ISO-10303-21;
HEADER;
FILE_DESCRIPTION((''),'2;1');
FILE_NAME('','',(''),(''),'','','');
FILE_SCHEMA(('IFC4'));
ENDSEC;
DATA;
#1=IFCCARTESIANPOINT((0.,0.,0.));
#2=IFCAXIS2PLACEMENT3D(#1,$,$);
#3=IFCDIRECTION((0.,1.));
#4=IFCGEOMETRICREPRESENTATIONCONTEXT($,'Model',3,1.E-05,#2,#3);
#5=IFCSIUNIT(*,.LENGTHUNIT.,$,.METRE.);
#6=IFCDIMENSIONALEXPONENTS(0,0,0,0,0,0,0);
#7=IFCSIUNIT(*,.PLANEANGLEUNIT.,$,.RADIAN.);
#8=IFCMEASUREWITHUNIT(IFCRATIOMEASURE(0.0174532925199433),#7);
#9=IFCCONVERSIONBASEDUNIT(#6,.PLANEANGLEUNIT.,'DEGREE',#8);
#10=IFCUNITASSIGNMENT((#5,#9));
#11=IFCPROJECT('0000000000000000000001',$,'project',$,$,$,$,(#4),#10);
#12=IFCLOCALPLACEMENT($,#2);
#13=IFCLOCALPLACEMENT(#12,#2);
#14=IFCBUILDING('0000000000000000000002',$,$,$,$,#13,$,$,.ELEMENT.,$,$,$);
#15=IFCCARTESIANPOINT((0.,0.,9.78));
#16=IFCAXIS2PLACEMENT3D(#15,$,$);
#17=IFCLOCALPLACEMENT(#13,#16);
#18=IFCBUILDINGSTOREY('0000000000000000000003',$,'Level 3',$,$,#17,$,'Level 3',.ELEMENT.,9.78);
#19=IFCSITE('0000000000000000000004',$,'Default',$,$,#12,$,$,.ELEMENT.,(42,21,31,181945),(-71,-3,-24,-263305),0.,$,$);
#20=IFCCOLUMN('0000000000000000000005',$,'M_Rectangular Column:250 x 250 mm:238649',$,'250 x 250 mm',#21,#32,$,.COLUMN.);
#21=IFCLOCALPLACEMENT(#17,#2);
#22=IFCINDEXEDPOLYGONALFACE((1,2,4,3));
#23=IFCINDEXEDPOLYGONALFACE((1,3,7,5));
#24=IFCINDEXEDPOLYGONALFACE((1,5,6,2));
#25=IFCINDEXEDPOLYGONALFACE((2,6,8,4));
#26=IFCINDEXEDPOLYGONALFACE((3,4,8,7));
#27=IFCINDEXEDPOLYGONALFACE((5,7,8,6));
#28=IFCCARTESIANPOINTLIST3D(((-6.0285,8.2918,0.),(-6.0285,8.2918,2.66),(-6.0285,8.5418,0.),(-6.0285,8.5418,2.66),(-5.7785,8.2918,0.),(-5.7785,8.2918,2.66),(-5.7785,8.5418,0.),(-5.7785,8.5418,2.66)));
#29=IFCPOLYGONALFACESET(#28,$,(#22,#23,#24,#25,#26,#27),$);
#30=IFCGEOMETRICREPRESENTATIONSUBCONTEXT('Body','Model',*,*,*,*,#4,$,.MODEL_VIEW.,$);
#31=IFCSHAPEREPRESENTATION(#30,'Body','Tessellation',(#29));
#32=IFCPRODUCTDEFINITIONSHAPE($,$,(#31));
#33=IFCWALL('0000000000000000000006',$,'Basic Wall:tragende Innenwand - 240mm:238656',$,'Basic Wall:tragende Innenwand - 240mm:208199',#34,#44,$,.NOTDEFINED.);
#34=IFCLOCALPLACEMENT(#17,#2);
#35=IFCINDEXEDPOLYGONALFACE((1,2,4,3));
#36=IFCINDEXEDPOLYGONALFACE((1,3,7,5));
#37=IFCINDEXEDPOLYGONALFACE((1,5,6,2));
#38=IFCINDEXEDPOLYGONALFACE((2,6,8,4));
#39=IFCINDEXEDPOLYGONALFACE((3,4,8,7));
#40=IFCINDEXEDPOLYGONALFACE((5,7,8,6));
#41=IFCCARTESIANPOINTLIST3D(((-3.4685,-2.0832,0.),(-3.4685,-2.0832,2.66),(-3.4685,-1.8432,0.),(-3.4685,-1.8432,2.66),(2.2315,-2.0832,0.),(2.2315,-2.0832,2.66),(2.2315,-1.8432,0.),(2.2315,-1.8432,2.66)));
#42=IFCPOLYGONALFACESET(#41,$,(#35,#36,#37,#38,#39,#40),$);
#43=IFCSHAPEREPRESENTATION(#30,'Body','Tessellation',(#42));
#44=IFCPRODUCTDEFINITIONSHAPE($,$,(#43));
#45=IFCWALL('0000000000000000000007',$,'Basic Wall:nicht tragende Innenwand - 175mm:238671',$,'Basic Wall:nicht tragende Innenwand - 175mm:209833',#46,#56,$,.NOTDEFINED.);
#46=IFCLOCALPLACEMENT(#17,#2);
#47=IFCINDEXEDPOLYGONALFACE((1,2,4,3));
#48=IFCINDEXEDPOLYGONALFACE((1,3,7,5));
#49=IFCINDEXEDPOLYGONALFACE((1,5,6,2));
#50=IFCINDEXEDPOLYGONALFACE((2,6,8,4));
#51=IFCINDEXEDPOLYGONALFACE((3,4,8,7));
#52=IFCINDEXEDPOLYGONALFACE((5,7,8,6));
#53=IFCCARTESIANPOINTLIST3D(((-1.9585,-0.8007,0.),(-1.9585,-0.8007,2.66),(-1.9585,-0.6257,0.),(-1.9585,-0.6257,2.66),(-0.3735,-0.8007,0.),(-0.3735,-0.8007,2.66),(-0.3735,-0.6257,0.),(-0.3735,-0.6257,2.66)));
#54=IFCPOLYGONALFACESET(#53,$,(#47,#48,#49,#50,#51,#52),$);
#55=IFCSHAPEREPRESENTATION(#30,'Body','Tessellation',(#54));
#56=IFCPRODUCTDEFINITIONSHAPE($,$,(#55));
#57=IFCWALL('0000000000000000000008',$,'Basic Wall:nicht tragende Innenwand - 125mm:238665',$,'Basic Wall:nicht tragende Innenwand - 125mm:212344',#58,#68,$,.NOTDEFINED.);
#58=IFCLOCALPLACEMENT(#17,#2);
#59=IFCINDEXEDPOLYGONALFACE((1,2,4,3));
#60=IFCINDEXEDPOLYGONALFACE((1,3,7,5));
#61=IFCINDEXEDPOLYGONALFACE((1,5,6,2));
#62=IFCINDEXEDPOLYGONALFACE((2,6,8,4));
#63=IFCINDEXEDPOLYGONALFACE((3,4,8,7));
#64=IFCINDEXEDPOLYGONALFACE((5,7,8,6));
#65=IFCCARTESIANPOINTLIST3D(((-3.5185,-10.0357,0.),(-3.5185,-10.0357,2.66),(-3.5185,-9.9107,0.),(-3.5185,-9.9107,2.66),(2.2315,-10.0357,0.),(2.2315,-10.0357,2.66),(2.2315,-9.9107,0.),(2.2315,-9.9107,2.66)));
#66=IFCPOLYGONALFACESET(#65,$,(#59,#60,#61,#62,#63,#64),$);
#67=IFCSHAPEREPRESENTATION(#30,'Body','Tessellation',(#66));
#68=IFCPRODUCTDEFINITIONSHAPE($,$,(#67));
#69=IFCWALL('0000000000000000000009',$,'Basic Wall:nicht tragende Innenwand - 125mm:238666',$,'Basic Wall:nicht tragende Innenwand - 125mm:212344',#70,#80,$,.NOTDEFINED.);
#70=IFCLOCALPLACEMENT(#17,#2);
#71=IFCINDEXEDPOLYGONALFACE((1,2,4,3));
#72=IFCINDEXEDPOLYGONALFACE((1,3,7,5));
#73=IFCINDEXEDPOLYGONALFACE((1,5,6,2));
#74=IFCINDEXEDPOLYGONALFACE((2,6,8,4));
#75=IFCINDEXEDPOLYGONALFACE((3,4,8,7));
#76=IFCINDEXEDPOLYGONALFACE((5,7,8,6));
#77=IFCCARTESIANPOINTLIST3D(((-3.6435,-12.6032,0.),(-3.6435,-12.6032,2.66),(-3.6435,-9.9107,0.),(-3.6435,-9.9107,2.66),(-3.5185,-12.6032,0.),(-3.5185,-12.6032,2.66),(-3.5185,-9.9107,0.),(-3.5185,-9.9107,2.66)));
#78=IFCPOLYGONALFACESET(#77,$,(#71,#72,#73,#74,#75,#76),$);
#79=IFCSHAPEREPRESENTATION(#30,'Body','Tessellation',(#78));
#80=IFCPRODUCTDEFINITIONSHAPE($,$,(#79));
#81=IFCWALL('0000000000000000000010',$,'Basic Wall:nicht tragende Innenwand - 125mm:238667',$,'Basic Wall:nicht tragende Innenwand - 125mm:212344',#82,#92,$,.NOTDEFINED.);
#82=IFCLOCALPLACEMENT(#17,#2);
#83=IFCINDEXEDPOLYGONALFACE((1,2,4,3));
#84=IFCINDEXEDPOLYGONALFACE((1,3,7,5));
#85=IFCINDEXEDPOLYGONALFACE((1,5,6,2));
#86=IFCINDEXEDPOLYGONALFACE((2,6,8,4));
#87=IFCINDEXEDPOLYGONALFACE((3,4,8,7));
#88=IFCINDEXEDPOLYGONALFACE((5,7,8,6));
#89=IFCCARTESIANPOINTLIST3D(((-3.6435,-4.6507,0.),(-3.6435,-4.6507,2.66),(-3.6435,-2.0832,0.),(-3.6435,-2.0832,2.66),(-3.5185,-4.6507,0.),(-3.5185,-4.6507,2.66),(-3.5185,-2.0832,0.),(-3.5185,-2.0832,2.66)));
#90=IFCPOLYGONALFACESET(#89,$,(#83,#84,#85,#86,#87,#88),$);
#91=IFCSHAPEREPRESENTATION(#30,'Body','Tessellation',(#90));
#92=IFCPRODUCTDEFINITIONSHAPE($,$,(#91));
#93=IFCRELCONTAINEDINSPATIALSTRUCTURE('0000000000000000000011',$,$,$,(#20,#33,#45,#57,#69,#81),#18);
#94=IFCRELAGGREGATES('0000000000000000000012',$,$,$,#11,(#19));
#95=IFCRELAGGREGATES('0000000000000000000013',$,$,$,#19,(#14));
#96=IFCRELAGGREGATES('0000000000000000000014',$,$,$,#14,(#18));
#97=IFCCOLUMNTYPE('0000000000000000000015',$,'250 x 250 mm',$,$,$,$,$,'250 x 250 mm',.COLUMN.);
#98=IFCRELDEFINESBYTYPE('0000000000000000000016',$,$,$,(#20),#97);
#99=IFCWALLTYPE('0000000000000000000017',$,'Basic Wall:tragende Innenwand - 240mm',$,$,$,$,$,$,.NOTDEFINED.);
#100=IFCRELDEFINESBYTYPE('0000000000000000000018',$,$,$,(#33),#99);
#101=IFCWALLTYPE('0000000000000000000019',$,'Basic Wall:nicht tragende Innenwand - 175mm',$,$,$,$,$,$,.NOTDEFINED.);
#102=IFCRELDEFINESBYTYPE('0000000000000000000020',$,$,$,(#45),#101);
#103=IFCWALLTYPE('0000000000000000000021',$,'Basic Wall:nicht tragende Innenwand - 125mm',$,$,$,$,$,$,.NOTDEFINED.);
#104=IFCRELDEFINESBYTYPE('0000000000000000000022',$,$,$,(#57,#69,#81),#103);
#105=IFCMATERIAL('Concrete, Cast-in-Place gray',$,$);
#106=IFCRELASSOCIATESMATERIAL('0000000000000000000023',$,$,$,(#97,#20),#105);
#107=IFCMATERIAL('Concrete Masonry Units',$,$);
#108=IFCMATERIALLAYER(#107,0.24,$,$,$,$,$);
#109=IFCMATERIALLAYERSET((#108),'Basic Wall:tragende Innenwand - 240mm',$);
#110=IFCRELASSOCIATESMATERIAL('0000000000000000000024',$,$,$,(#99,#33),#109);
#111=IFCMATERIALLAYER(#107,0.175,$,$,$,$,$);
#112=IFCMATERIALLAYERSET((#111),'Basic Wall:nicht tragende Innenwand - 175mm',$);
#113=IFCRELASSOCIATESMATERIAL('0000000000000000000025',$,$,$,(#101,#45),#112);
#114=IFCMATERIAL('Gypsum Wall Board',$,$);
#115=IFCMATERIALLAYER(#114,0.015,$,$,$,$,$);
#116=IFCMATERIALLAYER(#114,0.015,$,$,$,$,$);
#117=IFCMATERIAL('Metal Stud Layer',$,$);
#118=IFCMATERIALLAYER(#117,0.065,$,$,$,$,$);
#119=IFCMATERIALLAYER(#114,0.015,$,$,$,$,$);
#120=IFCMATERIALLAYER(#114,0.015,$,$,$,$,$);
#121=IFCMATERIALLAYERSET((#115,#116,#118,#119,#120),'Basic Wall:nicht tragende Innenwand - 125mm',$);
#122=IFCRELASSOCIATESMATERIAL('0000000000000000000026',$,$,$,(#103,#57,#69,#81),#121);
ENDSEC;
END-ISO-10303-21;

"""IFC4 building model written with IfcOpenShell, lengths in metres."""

from ifc_helpers import new_model, entity, si_unit, converted_unit, direction, frame, frame_2d, origin, place, context, subcontext, project, spatial, rectangle, extrude, source, transform, mapped, material, layer, layer_set, layer_usage, material_profile, profile_set, profile_usage, type_object, type_shapes, element, save


model = new_model("IFC4")

# Units and contexts
model_context = context("Model", 3, precision=1e-05, world=origin(), true_north=direction((0.0, 1.0)))
body_context = subcontext(model_context, "Body", "Model", "MODEL_VIEW")
ifc_project = project(units=[si_unit("LENGTHUNIT", "METRE"), converted_unit("PLANEANGLEUNIT", "DEGREE", entity("IfcRatioMeasure", 0.0174532925199433), si_unit("PLANEANGLEUNIT", "RADIAN"), dimensions=[0, 0, 0, 0, 0, 0, 0])], contexts=[model_context])

# Site, building, storey
site_placement = place(None, origin())
site = spatial("IfcSite", under=ifc_project, at=site_placement, Name="Default", CompositionType="ELEMENT", RefLatitude=(42, 21, 31, 181945), RefLongitude=(-71, -3, -24, -263305), RefElevation=0.0)
building_placement = place(site_placement, origin())
building = spatial("IfcBuilding", under=site, at=building_placement, CompositionType="ELEMENT")
storey_placement = place(building_placement, frame((0.0, 0.0, 9.78)))
storey = spatial("IfcBuildingStorey", under=building, at=storey_placement, Name="Level 3", LongName="Level 3", CompositionType="ELEMENT", Elevation=9.78)

# Column
ifc_material_1 = material(Name="Concrete, Cast-in-Place gray")
ifc_material_profile = material_profile(ifc_material_1, rectangle(XDim=0.25, YDim=0.25, at=frame_2d((0.0, 0.0), x_axis=(1.0, 0.0))))
ifc_profile_set = profile_set([ifc_material_profile], Name="250 x 250 mm")
ifc_profile_usage = profile_usage(ifc_profile_set)
column_type = type_object("IfcColumnType", Name="250 x 250 mm", ElementType="250 x 250 mm", PredefinedType="COLUMN", material=ifc_profile_set)
shared_shape_1 = source(origin(), body_context, "Body", "SweptSolid", [
    extrude(rectangle(XDim=0.25, YDim=0.25, at=frame_2d((0.0, 0.0), x_axis=(1.0, 0.0))), frame((-5.9035, 8.4168, 9.78), z_axis=(0.0, 0.0, 1.0), x_axis=(0.0, -1.0, 0.0)), (0.0, 0.0, 1.0), 2.66),
])
type_shapes(column_type, [shared_shape_1])
column_placement = place(storey_placement, frame((0.0, 0.0, -9.78)))
element("IfcColumn", 1, at=column_placement, inside=storey, type_object=column_type, material=ifc_profile_usage, Name="M_Rectangular Column:250 x 250 mm:238649", ObjectType="250 x 250 mm", PredefinedType="COLUMN", context=body_context, shape_type="MappedRepresentation", body=[
    mapped(shared_shape_1, transform((0.0, 0.0, 0.0), scale=1.0)),
])

# Walls
ifc_material_2 = material(Name="Concrete Masonry Units")
ifc_layer_1 = layer(ifc_material_2, 0.24)
ifc_layer_set_1 = layer_set([ifc_layer_1], Name="Basic Wall:tragende Innenwand - 240mm")
ifc_layer_usage_1 = layer_usage(ifc_layer_set_1, "AXIS2", "NEGATIVE", 0.12)
wall_type_1 = type_object("IfcWallType", Name="Basic Wall:tragende Innenwand - 240mm", PredefinedType="NOTDEFINED", material=ifc_layer_set_1)
wall_1_placement = place(storey_placement, frame((-3.4685, -1.9632, 0.0)))
element("IfcWall", 2, at=wall_1_placement, inside=storey, type_object=wall_type_1, material=ifc_layer_usage_1, Name="Basic Wall:tragende Innenwand - 240mm:238656", ObjectType="Basic Wall:tragende Innenwand - 240mm:208199", PredefinedType="NOTDEFINED", context=body_context, shape_type="SweptSolid", body=[
    extrude(rectangle(XDim=5.7, YDim=0.24, at=frame_2d((2.85, 0.0), x_axis=(-1.0, 0.0))), origin(), (0.0, 0.0, 1.0), 2.66),
])
ifc_layer_2 = layer(ifc_material_2, 0.175)
ifc_layer_set_2 = layer_set([ifc_layer_2], Name="Basic Wall:nicht tragende Innenwand - 175mm")
ifc_layer_usage_2 = layer_usage(ifc_layer_set_2, "AXIS2", "NEGATIVE", 0.0875)
wall_type_2 = type_object("IfcWallType", Name="Basic Wall:nicht tragende Innenwand - 175mm", PredefinedType="NOTDEFINED", material=ifc_layer_set_2)
wall_2_placement = place(storey_placement, frame((-1.9585, -0.7132, 0.0)))
element("IfcWall", 3, at=wall_2_placement, inside=storey, type_object=wall_type_2, material=ifc_layer_usage_2, Name="Basic Wall:nicht tragende Innenwand - 175mm:238671", ObjectType="Basic Wall:nicht tragende Innenwand - 175mm:209833", PredefinedType="NOTDEFINED", context=body_context, shape_type="SweptSolid", body=[
    extrude(rectangle(XDim=1.585, YDim=0.175, at=frame_2d((0.7925, 0.0), x_axis=(-1.0, 0.0))), origin(), (0.0, 0.0, 1.0), 2.66),
])
ifc_material_3 = material(Name="Gypsum Wall Board")
ifc_layer_3 = layer(ifc_material_3, 0.015)
ifc_layer_4 = layer(ifc_material_3, 0.015)
ifc_material_4 = material(Name="Metal Stud Layer")
ifc_layer_5 = layer(ifc_material_4, 0.065)
ifc_layer_6 = layer(ifc_material_3, 0.015)
ifc_layer_7 = layer(ifc_material_3, 0.015)
ifc_layer_set_3 = layer_set([ifc_layer_3, ifc_layer_4, ifc_layer_5, ifc_layer_6, ifc_layer_7], Name="Basic Wall:nicht tragende Innenwand - 125mm")
ifc_layer_usage_3 = layer_usage(ifc_layer_set_3, "AXIS2", "NEGATIVE", 0.0625)
wall_type_3 = type_object("IfcWallType", Name="Basic Wall:nicht tragende Innenwand - 125mm", PredefinedType="NOTDEFINED", material=ifc_layer_set_3)
wall_3_placement = place(storey_placement, frame((-3.5185, -9.9732, 0.0)))
element("IfcWall", 4, at=wall_3_placement, inside=storey, type_object=wall_type_3, material=ifc_layer_usage_3, Name="Basic Wall:nicht tragende Innenwand - 125mm:238665", ObjectType="Basic Wall:nicht tragende Innenwand - 125mm:212344", PredefinedType="NOTDEFINED", context=body_context, shape_type="SweptSolid", body=[
    extrude(rectangle(XDim=5.75, YDim=0.125, at=frame_2d((2.875, 0.0), x_axis=(-1.0, 0.0))), origin(), (0.0, 0.0, 1.0), 2.66),
])
ifc_layer_usage_4 = layer_usage(ifc_layer_set_3, "AXIS2", "NEGATIVE", 0.0625)
wall_4_placement = place(storey_placement, frame((-3.581, -9.9107, 0.0), z_axis=(0.0, 0.0, 1.0), x_axis=(0.0, -1.0, 0.0)))
element("IfcWall", 5, at=wall_4_placement, inside=storey, type_object=wall_type_3, material=ifc_layer_usage_4, Name="Basic Wall:nicht tragende Innenwand - 125mm:238666", ObjectType="Basic Wall:nicht tragende Innenwand - 125mm:212344", PredefinedType="NOTDEFINED", context=body_context, shape_type="SweptSolid", body=[
    extrude(rectangle(XDim=2.6925, YDim=0.125, at=frame_2d((1.3463, 0.0), x_axis=(-1.0, 0.0))), origin(), (0.0, 0.0, 1.0), 2.66),
])
ifc_layer_usage_5 = layer_usage(ifc_layer_set_3, "AXIS2", "NEGATIVE", 0.0625)
wall_5_placement = place(storey_placement, frame((-3.581, -2.0832, 0.0), z_axis=(0.0, 0.0, 1.0), x_axis=(0.0, -1.0, 0.0)))
element("IfcWall", 6, at=wall_5_placement, inside=storey, type_object=wall_type_3, material=ifc_layer_usage_5, Name="Basic Wall:nicht tragende Innenwand - 125mm:238667", ObjectType="Basic Wall:nicht tragende Innenwand - 125mm:212344", PredefinedType="NOTDEFINED", context=body_context, shape_type="SweptSolid", body=[
    extrude(rectangle(XDim=2.5675, YDim=0.125, at=frame_2d((1.2838, 0.0), x_axis=(-1.0, 0.0))), origin(), (0.0, 0.0, 1.0), 2.66),
])

save(model, "model.ifc")
